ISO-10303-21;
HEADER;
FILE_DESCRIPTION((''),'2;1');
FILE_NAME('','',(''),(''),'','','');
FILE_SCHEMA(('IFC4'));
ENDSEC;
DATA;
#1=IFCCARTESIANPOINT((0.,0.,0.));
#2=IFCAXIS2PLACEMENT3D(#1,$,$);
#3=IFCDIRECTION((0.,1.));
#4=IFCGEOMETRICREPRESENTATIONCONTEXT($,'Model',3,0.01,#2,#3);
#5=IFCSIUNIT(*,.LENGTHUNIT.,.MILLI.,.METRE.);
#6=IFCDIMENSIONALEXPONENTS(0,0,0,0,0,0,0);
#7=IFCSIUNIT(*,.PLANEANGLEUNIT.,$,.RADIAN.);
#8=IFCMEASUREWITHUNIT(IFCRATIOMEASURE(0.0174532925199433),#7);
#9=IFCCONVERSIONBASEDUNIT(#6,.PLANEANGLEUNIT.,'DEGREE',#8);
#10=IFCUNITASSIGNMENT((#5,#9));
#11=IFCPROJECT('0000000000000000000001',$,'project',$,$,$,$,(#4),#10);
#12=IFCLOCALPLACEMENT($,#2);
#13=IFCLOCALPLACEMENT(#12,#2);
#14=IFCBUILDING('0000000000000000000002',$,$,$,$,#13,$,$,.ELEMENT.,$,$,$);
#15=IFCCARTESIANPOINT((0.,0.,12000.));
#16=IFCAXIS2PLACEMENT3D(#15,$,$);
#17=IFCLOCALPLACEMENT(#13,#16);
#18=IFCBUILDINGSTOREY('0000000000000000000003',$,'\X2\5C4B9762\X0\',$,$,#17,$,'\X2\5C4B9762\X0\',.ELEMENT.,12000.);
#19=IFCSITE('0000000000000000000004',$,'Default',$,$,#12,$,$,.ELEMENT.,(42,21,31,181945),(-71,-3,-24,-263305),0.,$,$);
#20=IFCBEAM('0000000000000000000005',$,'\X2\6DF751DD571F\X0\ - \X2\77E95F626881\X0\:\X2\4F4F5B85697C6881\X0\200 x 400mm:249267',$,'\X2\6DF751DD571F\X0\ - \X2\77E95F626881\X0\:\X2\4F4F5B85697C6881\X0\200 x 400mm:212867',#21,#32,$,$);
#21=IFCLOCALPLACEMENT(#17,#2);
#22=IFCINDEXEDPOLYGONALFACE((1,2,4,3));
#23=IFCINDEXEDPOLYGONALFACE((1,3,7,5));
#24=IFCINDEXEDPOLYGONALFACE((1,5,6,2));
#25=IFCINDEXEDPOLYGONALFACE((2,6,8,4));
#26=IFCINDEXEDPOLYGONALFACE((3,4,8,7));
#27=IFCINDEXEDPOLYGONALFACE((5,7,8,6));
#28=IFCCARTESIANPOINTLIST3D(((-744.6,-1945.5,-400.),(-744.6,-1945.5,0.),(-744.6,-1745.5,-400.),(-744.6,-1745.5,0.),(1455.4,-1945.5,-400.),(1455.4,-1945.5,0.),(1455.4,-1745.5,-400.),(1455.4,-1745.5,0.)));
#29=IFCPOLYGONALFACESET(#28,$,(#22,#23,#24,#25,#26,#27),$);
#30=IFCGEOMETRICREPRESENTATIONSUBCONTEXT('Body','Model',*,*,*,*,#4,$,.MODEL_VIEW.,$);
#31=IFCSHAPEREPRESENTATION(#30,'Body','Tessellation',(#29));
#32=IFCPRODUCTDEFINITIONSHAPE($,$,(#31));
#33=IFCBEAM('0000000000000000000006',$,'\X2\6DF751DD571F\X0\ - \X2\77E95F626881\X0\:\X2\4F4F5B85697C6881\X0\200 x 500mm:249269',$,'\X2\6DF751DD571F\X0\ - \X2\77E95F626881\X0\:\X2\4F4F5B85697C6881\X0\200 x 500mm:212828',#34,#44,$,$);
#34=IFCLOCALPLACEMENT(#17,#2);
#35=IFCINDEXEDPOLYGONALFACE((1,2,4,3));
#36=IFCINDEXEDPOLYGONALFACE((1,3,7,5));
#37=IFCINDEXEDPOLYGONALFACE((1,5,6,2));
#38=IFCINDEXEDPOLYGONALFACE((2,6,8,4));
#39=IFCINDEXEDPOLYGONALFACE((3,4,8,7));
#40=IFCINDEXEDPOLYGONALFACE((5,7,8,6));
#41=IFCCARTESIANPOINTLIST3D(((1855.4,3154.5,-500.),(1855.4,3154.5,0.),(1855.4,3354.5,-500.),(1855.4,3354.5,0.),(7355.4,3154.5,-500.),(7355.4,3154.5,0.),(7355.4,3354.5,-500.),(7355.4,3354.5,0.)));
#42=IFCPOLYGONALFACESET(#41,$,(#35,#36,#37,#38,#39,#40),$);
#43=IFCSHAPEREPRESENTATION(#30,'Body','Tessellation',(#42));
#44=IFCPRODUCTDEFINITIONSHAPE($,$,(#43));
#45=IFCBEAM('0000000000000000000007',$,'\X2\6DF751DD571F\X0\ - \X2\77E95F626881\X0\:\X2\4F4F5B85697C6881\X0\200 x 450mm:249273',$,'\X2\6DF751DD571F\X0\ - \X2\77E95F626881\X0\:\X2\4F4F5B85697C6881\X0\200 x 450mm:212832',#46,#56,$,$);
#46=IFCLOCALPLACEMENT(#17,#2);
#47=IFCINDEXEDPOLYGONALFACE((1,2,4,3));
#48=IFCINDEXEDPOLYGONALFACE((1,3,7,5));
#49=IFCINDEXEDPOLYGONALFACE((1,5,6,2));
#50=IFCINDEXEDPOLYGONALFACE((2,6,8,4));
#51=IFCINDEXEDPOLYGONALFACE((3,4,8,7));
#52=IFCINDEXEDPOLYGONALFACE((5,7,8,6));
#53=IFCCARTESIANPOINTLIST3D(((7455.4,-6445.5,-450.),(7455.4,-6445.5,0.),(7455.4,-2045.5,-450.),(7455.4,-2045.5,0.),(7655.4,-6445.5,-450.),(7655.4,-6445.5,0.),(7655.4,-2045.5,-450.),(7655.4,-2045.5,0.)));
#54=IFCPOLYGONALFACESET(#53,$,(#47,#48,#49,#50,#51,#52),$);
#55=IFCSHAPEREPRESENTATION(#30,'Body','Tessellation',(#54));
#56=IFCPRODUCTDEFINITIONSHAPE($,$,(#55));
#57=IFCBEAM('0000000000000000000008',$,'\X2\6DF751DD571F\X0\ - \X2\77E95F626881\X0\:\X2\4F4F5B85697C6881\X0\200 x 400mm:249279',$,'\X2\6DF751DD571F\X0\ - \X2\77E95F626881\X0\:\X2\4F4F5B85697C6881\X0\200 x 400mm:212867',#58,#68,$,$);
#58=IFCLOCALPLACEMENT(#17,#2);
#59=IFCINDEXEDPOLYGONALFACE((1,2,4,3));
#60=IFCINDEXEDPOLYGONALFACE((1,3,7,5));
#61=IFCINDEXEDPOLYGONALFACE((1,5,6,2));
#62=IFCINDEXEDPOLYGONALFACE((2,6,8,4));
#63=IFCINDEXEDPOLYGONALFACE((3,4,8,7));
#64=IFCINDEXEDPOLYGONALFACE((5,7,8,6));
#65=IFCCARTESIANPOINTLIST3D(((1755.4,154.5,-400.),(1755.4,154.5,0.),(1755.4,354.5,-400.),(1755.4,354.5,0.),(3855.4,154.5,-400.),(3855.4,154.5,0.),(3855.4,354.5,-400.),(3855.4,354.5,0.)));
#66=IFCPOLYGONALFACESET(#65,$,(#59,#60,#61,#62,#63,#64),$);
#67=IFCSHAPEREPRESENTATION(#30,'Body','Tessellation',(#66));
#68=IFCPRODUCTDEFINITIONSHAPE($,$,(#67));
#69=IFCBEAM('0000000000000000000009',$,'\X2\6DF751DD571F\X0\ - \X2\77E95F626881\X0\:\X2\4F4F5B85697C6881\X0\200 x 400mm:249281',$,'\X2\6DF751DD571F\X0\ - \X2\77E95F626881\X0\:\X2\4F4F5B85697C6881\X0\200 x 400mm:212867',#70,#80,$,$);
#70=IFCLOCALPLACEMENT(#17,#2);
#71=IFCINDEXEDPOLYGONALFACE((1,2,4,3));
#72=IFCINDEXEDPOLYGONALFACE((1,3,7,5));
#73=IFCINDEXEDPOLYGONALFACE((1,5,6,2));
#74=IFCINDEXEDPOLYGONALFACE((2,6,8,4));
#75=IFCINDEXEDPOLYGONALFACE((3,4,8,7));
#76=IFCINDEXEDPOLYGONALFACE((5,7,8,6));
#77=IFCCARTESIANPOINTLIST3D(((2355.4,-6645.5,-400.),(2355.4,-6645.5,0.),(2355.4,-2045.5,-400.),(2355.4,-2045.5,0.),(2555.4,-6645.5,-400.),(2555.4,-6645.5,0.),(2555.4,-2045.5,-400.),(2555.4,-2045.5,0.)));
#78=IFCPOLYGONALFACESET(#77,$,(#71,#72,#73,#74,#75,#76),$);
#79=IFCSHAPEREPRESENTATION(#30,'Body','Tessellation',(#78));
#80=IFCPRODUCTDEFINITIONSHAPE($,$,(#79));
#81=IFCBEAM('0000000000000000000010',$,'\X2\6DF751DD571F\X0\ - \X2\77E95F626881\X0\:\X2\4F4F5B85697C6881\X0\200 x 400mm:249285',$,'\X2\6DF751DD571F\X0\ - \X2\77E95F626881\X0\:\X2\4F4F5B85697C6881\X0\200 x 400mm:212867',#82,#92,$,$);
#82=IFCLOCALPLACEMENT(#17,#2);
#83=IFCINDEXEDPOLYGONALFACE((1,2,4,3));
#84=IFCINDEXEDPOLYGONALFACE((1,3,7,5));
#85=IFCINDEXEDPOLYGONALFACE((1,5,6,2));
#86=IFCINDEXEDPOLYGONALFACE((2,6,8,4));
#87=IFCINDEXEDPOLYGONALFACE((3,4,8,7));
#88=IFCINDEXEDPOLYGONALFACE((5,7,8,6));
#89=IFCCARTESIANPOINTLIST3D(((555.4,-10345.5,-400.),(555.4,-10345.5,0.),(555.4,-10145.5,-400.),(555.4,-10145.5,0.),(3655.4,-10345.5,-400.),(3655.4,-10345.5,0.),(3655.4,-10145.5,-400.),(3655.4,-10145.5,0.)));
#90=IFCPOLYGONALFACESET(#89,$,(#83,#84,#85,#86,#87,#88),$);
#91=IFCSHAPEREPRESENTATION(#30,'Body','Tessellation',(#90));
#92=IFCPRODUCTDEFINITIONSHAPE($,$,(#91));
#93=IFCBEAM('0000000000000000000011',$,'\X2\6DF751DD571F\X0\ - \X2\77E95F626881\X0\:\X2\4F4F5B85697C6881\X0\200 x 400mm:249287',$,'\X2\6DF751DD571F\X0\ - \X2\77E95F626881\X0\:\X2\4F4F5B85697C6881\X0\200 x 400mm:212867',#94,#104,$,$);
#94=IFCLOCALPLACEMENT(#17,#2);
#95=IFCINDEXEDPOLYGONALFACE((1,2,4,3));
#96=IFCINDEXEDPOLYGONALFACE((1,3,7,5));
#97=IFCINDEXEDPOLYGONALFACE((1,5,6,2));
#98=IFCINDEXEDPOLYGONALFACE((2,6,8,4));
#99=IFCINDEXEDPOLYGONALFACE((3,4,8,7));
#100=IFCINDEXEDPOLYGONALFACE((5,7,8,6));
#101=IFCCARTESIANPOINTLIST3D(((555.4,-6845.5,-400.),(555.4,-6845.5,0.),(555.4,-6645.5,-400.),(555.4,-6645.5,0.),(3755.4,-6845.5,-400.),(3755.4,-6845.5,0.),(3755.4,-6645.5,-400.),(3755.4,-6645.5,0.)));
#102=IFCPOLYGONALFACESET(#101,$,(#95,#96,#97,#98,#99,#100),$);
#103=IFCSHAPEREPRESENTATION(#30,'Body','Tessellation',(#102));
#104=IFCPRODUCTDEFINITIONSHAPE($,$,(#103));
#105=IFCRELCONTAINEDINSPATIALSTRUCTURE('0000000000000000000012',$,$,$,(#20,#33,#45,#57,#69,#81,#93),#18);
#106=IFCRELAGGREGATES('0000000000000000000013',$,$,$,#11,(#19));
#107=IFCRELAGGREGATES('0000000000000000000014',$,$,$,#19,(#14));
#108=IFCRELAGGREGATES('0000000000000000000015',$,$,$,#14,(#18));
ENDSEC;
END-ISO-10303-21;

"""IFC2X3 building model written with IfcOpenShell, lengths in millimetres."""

from ifc_helpers import new_model, entity, si_unit, converted_unit, direction, frame, frame_2d, origin, origin_2d_with_axis, place, context, subcontext, project, spatial, rectangle, extrude, element, save


model = new_model("IFC2X3")

# Units and contexts
model_context = context("Model", 3, precision=0.01, world=origin(), true_north=direction((0.0, 1.0)))
body_context = subcontext(model_context, "Body", "Model", "MODEL_VIEW")
ifc_project = project(units=[si_unit("LENGTHUNIT", "METRE", prefix="MILLI"), converted_unit("PLANEANGLEUNIT", "DEGREE", entity("IfcRatioMeasure", 0.0174532925199433), si_unit("PLANEANGLEUNIT", "RADIAN"), dimensions=[0, 0, 0, 0, 0, 0, 0])], contexts=[model_context])

# Site, building, storey
site_placement = place(None, origin())
site = spatial("IfcSite", under=ifc_project, at=site_placement, Name="Default", CompositionType="ELEMENT", RefLatitude=(42, 21, 31, 181945), RefLongitude=(-71, -3, -24, -263305), RefElevation=0.0)
building_placement = place(site_placement, origin())
building = spatial("IfcBuilding", under=site, at=building_placement, CompositionType="ELEMENT")
storey_placement = place(building_placement, frame((0.0, 0.0, 12000.0)))
storey = spatial("IfcBuildingStorey", under=building, at=storey_placement, Name="屋面", LongName="屋面", CompositionType="ELEMENT", Elevation=12000.0)

# Beams
beam_1_placement = place(storey_placement, frame((-944.6, -1845.5, 0.0)))
element("IfcBeam", 1, at=beam_1_placement, inside=storey, Name="混凝土 - 矩形梁:住宅楼梁200 x 400mm:249267", ObjectType="混凝土 - 矩形梁:住宅楼梁200 x 400mm:212867", context=body_context, shape_type="SweptSolid", body=[
    extrude(rectangle(XDim=400.0, YDim=200.0, at=frame_2d((0.0, 0.0), x_axis=(1.0, 0.0))), frame((200.0, 0.0, -200.0), z_axis=(1.0, 0.0, 0.0), x_axis=(0.0, 0.0, -1.0)), (0.0, 0.0, 1.0), 2200.0),
])
beam_2_placement = place(storey_placement, frame((7555.4, 3254.5, 0.0), z_axis=(0.0, 0.0, 1.0), x_axis=(-1.0, 0.0, 0.0)))
element("IfcBeam", 2, at=beam_2_placement, inside=storey, Name="混凝土 - 矩形梁:住宅楼梁200 x 500mm:249269", ObjectType="混凝土 - 矩形梁:住宅楼梁200 x 500mm:212828", context=body_context, shape_type="SweptSolid", body=[
    extrude(rectangle(XDim=500.0, YDim=200.0, at=frame_2d((0.0, 0.0), x_axis=(1.0, 0.0))), frame((200.0, 0.0, -250.0), z_axis=(1.0, 0.0, 0.0), x_axis=(0.0, 0.0, -1.0)), (0.0, 0.0, 1.0), 5500.0),
])
beam_3_placement = place(storey_placement, frame((7555.4, -1945.5, 0.0), z_axis=(0.0, 0.0, 1.0), x_axis=(0.0, -1.0, 0.0)))
element("IfcBeam", 3, at=beam_3_placement, inside=storey, Name="混凝土 - 矩形梁:住宅楼梁200 x 450mm:249273", ObjectType="混凝土 - 矩形梁:住宅楼梁200 x 450mm:212832", context=body_context, shape_type="SweptSolid", body=[
    extrude(rectangle(XDim=450.0, YDim=200.0, at=frame_2d((0.0, 0.0), x_axis=(1.0, 0.0))), frame((100.0, 0.0, -225.0), z_axis=(1.0, 0.0, 0.0), x_axis=(0.0, 0.0, -1.0)), (0.0, 0.0, 1.0), 4400.0),
])
beam_4_placement = place(storey_placement, frame((3955.4, 254.5, 0.0), z_axis=(0.0, 0.0, 1.0), x_axis=(-1.0, 0.0, 0.0)))
element("IfcBeam", 4, at=beam_4_placement, inside=storey, Name="混凝土 - 矩形梁:住宅楼梁200 x 400mm:249279", ObjectType="混凝土 - 矩形梁:住宅楼梁200 x 400mm:212867", context=body_context, shape_type="SweptSolid", body=[
    extrude(rectangle(XDim=400.0, YDim=200.0, at=frame_2d((0.0, 0.0), x_axis=(1.0, 0.0))), frame((100.0, 0.0, -200.0), z_axis=(1.0, 0.0, 0.0), x_axis=(0.0, 0.0, -1.0)), (0.0, 0.0, 1.0), 2100.0),
])
beam_5_placement = place(storey_placement, frame((2455.4, -1945.5, 0.0), z_axis=(0.0, 0.0, 1.0), x_axis=(0.0, -1.0, 0.0)))
element("IfcBeam", 5, at=beam_5_placement, inside=storey, Name="混凝土 - 矩形梁:住宅楼梁200 x 400mm:249281", ObjectType="混凝土 - 矩形梁:住宅楼梁200 x 400mm:212867", context=body_context, shape_type="SweptSolid", body=[
    extrude(rectangle(XDim=400.0, YDim=200.0, at=origin_2d_with_axis()), frame((100.0, 0.0, -200.0), z_axis=(1.0, 0.0, 0.0), x_axis=(0.0, 0.0, -1.0)), (0.0, 0.0, 1.0), 4600.0),
])
beam_6_placement = place(storey_placement, frame((3655.4, -10245.5, 0.0), z_axis=(0.0, 0.0, 1.0), x_axis=(-1.0, 0.0, 0.0)))
element("IfcBeam", 6, at=beam_6_placement, inside=storey, Name="混凝土 - 矩形梁:住宅楼梁200 x 400mm:249285", ObjectType="混凝土 - 矩形梁:住宅楼梁200 x 400mm:212867", context=body_context, shape_type="SweptSolid", body=[
    extrude(rectangle(XDim=400.0, YDim=200.0, at=frame_2d((0.0, 0.0), x_axis=(1.0, 0.0))), frame((0.0, 0.0, -200.0), z_axis=(1.0, 0.0, 0.0), x_axis=(0.0, 0.0, -1.0)), (0.0, 0.0, 1.0), 3100.0),
])
beam_7_placement = place(storey_placement, frame((3955.4, -6745.5, 0.0), z_axis=(0.0, 0.0, 1.0), x_axis=(-1.0, 0.0, 0.0)))
element("IfcBeam", 7, at=beam_7_placement, inside=storey, Name="混凝土 - 矩形梁:住宅楼梁200 x 400mm:249287", ObjectType="混凝土 - 矩形梁:住宅楼梁200 x 400mm:212867", context=body_context, shape_type="SweptSolid", body=[
    extrude(rectangle(XDim=400.0, YDim=200.0, at=frame_2d((0.0, 0.0), x_axis=(1.0, 0.0))), frame((200.0, 0.0, -200.0), z_axis=(1.0, 0.0, 0.0), x_axis=(0.0, 0.0, -1.0)), (0.0, 0.0, 1.0), 3200.0),
])

save(model, "model.ifc")
